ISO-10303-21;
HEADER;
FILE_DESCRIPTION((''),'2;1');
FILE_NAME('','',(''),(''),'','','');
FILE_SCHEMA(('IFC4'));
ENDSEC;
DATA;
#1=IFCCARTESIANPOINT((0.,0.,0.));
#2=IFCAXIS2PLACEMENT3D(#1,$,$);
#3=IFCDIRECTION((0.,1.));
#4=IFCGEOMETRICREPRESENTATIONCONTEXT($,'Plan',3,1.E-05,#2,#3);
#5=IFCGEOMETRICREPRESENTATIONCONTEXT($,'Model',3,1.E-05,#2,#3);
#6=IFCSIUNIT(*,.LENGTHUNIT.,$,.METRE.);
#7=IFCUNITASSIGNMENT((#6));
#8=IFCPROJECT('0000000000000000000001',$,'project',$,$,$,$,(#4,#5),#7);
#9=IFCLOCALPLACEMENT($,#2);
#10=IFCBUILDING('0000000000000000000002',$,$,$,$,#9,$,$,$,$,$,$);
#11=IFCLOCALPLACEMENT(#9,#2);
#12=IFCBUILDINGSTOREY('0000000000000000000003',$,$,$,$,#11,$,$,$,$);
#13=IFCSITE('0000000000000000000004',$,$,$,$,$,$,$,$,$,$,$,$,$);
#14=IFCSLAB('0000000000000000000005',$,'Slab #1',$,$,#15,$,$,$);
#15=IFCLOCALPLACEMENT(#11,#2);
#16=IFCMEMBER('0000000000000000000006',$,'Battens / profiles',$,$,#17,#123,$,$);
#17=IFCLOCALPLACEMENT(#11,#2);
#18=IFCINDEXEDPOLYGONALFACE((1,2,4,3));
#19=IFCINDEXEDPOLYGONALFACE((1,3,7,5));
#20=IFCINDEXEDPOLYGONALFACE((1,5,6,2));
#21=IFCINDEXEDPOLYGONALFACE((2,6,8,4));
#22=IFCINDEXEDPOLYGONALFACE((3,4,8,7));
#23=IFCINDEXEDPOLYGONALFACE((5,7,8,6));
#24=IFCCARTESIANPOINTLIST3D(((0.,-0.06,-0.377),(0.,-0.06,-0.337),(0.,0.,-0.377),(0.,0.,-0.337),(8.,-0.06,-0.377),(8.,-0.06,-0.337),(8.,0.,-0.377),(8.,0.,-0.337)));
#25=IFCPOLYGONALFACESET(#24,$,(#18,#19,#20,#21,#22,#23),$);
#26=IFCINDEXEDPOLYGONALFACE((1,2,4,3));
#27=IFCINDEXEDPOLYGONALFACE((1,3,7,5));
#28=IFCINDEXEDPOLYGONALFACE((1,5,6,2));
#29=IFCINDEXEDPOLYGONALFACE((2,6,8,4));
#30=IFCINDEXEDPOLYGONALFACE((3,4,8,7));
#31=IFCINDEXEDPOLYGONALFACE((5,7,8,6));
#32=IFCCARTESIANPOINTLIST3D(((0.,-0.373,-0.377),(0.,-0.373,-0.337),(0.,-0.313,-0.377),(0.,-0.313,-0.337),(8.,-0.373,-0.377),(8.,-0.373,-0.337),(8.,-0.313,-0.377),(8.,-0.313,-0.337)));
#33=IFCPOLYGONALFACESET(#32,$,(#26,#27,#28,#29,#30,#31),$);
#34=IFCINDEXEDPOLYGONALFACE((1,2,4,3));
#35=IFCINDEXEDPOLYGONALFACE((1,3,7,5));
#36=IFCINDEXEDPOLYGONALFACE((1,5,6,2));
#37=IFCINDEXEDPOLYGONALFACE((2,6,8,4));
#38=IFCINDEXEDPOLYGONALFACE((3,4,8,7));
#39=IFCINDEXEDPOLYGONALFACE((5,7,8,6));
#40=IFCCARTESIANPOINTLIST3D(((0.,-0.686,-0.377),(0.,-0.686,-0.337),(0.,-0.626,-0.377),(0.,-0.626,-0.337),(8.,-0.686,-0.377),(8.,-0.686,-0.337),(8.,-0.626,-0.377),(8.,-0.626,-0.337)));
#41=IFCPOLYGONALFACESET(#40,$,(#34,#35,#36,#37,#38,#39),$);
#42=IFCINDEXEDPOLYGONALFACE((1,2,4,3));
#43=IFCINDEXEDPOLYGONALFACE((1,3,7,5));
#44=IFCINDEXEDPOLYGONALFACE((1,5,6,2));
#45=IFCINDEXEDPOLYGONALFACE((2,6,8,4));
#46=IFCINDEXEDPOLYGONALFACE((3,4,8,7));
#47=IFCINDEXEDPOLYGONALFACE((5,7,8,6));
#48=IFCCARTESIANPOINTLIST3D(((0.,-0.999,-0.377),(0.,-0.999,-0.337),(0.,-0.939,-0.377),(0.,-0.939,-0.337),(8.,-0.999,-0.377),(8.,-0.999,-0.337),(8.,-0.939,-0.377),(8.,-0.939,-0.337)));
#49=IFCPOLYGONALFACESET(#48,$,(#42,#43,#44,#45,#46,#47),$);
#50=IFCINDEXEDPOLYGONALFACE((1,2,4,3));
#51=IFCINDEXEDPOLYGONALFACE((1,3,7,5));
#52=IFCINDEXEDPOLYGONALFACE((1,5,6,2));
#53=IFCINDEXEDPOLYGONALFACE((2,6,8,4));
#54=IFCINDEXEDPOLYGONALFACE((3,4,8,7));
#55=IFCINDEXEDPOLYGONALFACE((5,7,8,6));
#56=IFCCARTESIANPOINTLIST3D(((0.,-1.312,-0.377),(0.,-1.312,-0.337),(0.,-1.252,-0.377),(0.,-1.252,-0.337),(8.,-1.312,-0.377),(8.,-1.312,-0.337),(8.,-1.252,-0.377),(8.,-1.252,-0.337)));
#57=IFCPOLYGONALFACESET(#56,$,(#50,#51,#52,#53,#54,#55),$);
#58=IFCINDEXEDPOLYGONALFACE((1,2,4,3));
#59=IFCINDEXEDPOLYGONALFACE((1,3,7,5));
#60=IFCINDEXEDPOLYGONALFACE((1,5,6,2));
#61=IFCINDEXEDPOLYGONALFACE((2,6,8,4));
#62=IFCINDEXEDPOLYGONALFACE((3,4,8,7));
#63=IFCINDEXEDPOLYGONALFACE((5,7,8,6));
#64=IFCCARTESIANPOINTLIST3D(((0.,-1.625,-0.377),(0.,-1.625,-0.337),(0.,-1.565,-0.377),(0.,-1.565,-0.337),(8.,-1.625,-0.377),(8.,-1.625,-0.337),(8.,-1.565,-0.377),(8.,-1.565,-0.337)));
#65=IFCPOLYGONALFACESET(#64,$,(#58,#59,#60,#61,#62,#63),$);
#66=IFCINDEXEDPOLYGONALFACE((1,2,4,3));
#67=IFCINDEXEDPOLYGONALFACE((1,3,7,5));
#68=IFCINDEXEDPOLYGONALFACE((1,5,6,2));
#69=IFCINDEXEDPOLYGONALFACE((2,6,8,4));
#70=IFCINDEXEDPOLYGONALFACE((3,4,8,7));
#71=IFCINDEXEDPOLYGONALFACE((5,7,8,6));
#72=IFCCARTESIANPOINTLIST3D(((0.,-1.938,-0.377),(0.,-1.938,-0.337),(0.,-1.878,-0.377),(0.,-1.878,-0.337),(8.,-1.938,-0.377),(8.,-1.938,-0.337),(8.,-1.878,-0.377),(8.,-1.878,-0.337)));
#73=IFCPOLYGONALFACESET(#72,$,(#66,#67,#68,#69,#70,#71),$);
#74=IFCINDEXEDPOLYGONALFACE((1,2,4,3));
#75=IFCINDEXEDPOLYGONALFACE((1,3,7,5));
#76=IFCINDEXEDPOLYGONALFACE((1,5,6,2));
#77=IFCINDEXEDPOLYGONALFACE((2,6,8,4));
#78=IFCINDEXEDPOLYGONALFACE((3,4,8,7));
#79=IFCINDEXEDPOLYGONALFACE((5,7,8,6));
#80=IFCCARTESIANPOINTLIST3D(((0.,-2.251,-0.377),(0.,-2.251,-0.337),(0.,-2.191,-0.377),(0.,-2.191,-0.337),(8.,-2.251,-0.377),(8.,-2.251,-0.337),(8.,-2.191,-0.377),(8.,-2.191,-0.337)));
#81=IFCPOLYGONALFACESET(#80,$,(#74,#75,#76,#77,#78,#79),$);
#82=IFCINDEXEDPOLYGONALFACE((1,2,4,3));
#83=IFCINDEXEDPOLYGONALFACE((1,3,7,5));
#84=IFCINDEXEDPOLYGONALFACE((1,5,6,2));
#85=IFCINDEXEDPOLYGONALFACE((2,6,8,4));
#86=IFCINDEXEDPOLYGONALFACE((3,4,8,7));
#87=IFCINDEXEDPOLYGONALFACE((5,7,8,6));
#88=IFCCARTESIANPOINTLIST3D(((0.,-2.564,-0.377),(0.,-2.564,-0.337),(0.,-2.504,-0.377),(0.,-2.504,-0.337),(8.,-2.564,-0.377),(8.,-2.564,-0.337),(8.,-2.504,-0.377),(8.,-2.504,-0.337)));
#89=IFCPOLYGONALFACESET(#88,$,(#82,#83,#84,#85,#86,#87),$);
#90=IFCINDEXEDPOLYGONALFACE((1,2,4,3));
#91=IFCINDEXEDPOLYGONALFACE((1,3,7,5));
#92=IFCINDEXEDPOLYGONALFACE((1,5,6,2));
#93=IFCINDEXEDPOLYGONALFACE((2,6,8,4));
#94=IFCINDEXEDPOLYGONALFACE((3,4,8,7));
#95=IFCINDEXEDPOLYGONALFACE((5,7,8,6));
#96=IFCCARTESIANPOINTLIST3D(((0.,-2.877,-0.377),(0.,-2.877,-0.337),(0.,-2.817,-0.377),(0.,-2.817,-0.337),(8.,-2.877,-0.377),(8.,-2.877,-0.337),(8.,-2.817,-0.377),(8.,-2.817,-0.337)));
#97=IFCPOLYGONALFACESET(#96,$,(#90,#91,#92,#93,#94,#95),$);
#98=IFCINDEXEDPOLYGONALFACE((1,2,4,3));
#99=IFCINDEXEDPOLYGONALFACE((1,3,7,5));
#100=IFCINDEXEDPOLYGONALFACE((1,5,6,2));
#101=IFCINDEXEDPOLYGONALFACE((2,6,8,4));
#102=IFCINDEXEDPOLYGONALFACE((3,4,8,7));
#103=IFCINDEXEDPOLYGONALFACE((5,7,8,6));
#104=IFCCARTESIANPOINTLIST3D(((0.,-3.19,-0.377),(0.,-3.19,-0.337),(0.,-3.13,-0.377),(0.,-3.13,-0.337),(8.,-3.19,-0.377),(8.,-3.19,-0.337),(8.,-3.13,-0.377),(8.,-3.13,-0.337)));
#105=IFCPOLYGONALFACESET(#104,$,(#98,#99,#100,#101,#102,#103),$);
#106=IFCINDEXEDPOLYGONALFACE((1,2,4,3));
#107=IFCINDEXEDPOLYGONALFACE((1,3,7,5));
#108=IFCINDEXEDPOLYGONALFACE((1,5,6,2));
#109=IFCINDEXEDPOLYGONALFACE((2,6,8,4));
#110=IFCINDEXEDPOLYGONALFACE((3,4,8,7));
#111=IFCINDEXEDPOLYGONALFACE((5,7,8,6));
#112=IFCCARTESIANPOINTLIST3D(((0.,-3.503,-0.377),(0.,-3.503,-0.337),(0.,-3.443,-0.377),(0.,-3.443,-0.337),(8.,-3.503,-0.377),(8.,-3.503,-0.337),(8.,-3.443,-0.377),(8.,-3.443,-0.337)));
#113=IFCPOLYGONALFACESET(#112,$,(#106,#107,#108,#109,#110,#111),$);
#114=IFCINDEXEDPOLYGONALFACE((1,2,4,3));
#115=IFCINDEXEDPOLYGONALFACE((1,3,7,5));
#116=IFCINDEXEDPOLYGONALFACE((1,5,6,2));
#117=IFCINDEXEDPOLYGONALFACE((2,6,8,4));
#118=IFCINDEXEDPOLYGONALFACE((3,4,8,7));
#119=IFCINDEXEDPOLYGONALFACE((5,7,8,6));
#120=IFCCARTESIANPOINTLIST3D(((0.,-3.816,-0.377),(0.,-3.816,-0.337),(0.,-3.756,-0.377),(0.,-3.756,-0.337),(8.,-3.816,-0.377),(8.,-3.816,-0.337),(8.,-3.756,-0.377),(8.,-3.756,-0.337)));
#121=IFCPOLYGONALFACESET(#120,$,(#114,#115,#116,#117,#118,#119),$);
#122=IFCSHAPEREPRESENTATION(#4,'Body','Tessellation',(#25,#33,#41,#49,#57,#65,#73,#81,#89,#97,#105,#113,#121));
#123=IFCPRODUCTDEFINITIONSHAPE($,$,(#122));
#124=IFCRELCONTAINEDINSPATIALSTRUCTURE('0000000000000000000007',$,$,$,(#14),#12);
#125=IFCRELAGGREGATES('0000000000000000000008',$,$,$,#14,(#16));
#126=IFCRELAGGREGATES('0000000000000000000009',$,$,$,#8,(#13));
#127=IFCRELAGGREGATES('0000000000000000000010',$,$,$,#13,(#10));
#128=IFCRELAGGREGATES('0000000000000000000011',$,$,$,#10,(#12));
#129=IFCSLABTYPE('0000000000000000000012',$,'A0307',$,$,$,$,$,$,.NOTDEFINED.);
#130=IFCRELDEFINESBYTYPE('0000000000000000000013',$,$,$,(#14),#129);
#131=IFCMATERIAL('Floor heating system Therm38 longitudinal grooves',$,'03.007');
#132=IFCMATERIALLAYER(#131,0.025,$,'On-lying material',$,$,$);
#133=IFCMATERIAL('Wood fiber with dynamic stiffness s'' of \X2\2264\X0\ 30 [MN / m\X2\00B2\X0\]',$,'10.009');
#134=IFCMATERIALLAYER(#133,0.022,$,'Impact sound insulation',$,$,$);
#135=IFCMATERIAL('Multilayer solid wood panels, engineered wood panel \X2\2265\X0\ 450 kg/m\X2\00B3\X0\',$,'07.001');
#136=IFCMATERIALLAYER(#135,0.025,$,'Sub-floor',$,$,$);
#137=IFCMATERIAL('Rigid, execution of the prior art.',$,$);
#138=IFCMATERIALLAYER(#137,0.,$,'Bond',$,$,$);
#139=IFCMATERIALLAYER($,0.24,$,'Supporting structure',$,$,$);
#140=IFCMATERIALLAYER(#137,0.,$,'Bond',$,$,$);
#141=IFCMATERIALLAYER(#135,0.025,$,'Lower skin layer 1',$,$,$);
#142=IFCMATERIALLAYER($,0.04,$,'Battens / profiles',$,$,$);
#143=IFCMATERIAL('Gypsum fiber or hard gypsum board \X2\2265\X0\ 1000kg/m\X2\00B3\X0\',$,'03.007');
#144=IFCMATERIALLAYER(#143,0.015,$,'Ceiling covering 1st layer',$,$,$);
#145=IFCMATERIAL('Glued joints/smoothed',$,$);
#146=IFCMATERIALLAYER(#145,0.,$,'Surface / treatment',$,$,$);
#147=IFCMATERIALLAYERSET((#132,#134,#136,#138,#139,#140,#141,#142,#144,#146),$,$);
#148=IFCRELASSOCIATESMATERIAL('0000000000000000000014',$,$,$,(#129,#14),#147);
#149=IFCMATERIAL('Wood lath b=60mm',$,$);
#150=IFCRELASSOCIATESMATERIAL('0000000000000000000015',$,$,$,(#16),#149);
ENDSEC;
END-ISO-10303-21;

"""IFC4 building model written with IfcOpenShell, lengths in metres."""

from ifc_helpers import new_model, si_unit, direction, frame, frame_2d, origin, place, context, project, spatial, rectangle, extrude, material, layer, layer_set, type_object, element, aggregate, save


model = new_model("IFC4")

# Units and contexts
plan_context = context("Plan", 3, precision=1e-05, world=origin(), true_north=direction((0.0, 1.0)))
model_context = context("Model", 3, precision=1e-05, world=origin(), true_north=direction((0.0, 1.0)))
ifc_project = project(units=[si_unit("LENGTHUNIT", "METRE")], contexts=[plan_context, model_context])

# Site, building, storey
site = spatial("IfcSite", under=ifc_project)
building_placement = place(None, origin())
building = spatial("IfcBuilding", under=site, at=building_placement)
storey_placement = place(building_placement, origin())
storey = spatial("IfcBuildingStorey", under=building, at=storey_placement)

# Slab, member
ifc_material_1 = material(Name="Floor heating system Therm38 longitudinal grooves", Category="03.007")
ifc_layer_1 = layer(ifc_material_1, 0.025, Name="On-lying material")
ifc_material_2 = material(Name="Wood fiber with dynamic stiffness s' of ≤ 30 [MN / m²]", Category="10.009")
ifc_layer_2 = layer(ifc_material_2, 0.022, Name="Impact sound insulation")
ifc_material_3 = material(Name="Multilayer solid wood panels, engineered wood panel ≥ 450 kg/m³", Category="07.001")
ifc_layer_3 = layer(ifc_material_3, 0.025, Name="Sub-floor")
ifc_material_4 = material(Name="Rigid, execution of the prior art.")
ifc_layer_4 = layer(ifc_material_4, 0.0, Name="Bond")
ifc_layer_5 = layer(None, 0.24, Name="Supporting structure")
ifc_layer_6 = layer(ifc_material_4, 0.0, Name="Bond")
ifc_layer_7 = layer(ifc_material_3, 0.025, Name="Lower skin layer 1")
ifc_layer_8 = layer(None, 0.04, Name="Battens / profiles")
ifc_material_5 = material(Name="Gypsum fiber or hard gypsum board ≥ 1000kg/m³", Category="03.007")
ifc_layer_9 = layer(ifc_material_5, 0.015, Name="Ceiling covering 1st layer")
ifc_material_6 = material(Name="Glued joints/smoothed")
ifc_layer_10 = layer(ifc_material_6, 0.0, Name="Surface / treatment")
ifc_layer_set = layer_set([ifc_layer_1, ifc_layer_2, ifc_layer_3, ifc_layer_4, ifc_layer_5, ifc_layer_6, ifc_layer_7, ifc_layer_8, ifc_layer_9, ifc_layer_10])
slab_type = type_object("IfcSlabType", Name="A0307", PredefinedType="NOTDEFINED", material=ifc_layer_set)
slab_placement = place(None, frame((0.0, 0.0, 0.0), z_axis=(0.0, 0.0, -1.0), x_axis=(1.0, 0.0, 0.0)))
slab = element("IfcSlab", 1, at=slab_placement, inside=storey, type_object=slab_type, material=ifc_layer_set, Name="Slab #1")
ifc_material_7 = material(Name="Wood lath b=60mm")
member_1_placement = place(slab_placement, origin())
member_1 = element("IfcMember", 2, at=member_1_placement, material=ifc_material_7, Name="Battens / profiles", context=plan_context, shape_type="SweptSolid", body=[
    extrude(rectangle(XDim=0.06, YDim=0.04, at=frame_2d((0.03, 0.02), x_axis=(1.0, 0.0))), frame((0.0, 0.0, 0.337), z_axis=(1.0, 0.0, 0.0), x_axis=(0.0, 1.0, 0.0)), (0.0, 0.0, 1.0), 8.0),
    extrude(rectangle(XDim=0.06, YDim=0.04, at=frame_2d((0.03, 0.02), x_axis=(1.0, 0.0))), frame((0.0, 0.313, 0.337), z_axis=(1.0, 0.0, 0.0), x_axis=(0.0, 1.0, 0.0)), (0.0, 0.0, 1.0), 8.0),
    extrude(rectangle(XDim=0.06, YDim=0.04, at=frame_2d((0.03, 0.02), x_axis=(1.0, 0.0))), frame((0.0, 0.626, 0.337), z_axis=(1.0, 0.0, 0.0), x_axis=(0.0, 1.0, 0.0)), (0.0, 0.0, 1.0), 8.0),
    extrude(rectangle(XDim=0.06, YDim=0.04, at=frame_2d((0.03, 0.02), x_axis=(1.0, 0.0))), frame((0.0, 0.939, 0.337), z_axis=(1.0, 0.0, 0.0), x_axis=(0.0, 1.0, 0.0)), (0.0, 0.0, 1.0), 8.0),
    extrude(rectangle(XDim=0.06, YDim=0.04, at=frame_2d((0.03, 0.02), x_axis=(1.0, 0.0))), frame((0.0, 1.252, 0.337), z_axis=(1.0, 0.0, 0.0), x_axis=(0.0, 1.0, 0.0)), (0.0, 0.0, 1.0), 8.0),
    extrude(rectangle(XDim=0.06, YDim=0.04, at=frame_2d((0.03, 0.02), x_axis=(1.0, 0.0))), frame((0.0, 1.565, 0.337), z_axis=(1.0, 0.0, 0.0), x_axis=(0.0, 1.0, 0.0)), (0.0, 0.0, 1.0), 8.0),
    extrude(rectangle(XDim=0.06, YDim=0.04, at=frame_2d((0.03, 0.02), x_axis=(1.0, 0.0))), frame((0.0, 1.878, 0.337), z_axis=(1.0, 0.0, 0.0), x_axis=(0.0, 1.0, 0.0)), (0.0, 0.0, 1.0), 8.0),
    extrude(rectangle(XDim=0.06, YDim=0.04, at=frame_2d((0.03, 0.02), x_axis=(1.0, 0.0))), frame((0.0, 2.191, 0.337), z_axis=(1.0, 0.0, 0.0), x_axis=(0.0, 1.0, 0.0)), (0.0, 0.0, 1.0), 8.0),
    extrude(rectangle(XDim=0.06, YDim=0.04, at=frame_2d((0.03, 0.02), x_axis=(1.0, 0.0))), frame((0.0, 2.504, 0.337), z_axis=(1.0, 0.0, 0.0), x_axis=(0.0, 1.0, 0.0)), (0.0, 0.0, 1.0), 8.0),
    extrude(rectangle(XDim=0.06, YDim=0.04, at=frame_2d((0.03, 0.02), x_axis=(1.0, 0.0))), frame((0.0, 2.817, 0.337), z_axis=(1.0, 0.0, 0.0), x_axis=(0.0, 1.0, 0.0)), (0.0, 0.0, 1.0), 8.0),
    extrude(rectangle(XDim=0.06, YDim=0.04, at=frame_2d((0.03, 0.02), x_axis=(1.0, 0.0))), frame((0.0, 3.13, 0.337), z_axis=(1.0, 0.0, 0.0), x_axis=(0.0, 1.0, 0.0)), (0.0, 0.0, 1.0), 8.0),
    extrude(rectangle(XDim=0.06, YDim=0.04, at=frame_2d((0.03, 0.02), x_axis=(1.0, 0.0))), frame((0.0, 3.443, 0.337), z_axis=(1.0, 0.0, 0.0), x_axis=(0.0, 1.0, 0.0)), (0.0, 0.0, 1.0), 8.0),
    extrude(rectangle(XDim=0.06, YDim=0.04, at=frame_2d((0.03, 0.02), x_axis=(1.0, 0.0))), frame((0.0, 3.756, 0.337), z_axis=(1.0, 0.0, 0.0), x_axis=(0.0, 1.0, 0.0)), (0.0, 0.0, 1.0), 8.0),
])
aggregate(slab, [member_1])

save(model, "model.ifc")
